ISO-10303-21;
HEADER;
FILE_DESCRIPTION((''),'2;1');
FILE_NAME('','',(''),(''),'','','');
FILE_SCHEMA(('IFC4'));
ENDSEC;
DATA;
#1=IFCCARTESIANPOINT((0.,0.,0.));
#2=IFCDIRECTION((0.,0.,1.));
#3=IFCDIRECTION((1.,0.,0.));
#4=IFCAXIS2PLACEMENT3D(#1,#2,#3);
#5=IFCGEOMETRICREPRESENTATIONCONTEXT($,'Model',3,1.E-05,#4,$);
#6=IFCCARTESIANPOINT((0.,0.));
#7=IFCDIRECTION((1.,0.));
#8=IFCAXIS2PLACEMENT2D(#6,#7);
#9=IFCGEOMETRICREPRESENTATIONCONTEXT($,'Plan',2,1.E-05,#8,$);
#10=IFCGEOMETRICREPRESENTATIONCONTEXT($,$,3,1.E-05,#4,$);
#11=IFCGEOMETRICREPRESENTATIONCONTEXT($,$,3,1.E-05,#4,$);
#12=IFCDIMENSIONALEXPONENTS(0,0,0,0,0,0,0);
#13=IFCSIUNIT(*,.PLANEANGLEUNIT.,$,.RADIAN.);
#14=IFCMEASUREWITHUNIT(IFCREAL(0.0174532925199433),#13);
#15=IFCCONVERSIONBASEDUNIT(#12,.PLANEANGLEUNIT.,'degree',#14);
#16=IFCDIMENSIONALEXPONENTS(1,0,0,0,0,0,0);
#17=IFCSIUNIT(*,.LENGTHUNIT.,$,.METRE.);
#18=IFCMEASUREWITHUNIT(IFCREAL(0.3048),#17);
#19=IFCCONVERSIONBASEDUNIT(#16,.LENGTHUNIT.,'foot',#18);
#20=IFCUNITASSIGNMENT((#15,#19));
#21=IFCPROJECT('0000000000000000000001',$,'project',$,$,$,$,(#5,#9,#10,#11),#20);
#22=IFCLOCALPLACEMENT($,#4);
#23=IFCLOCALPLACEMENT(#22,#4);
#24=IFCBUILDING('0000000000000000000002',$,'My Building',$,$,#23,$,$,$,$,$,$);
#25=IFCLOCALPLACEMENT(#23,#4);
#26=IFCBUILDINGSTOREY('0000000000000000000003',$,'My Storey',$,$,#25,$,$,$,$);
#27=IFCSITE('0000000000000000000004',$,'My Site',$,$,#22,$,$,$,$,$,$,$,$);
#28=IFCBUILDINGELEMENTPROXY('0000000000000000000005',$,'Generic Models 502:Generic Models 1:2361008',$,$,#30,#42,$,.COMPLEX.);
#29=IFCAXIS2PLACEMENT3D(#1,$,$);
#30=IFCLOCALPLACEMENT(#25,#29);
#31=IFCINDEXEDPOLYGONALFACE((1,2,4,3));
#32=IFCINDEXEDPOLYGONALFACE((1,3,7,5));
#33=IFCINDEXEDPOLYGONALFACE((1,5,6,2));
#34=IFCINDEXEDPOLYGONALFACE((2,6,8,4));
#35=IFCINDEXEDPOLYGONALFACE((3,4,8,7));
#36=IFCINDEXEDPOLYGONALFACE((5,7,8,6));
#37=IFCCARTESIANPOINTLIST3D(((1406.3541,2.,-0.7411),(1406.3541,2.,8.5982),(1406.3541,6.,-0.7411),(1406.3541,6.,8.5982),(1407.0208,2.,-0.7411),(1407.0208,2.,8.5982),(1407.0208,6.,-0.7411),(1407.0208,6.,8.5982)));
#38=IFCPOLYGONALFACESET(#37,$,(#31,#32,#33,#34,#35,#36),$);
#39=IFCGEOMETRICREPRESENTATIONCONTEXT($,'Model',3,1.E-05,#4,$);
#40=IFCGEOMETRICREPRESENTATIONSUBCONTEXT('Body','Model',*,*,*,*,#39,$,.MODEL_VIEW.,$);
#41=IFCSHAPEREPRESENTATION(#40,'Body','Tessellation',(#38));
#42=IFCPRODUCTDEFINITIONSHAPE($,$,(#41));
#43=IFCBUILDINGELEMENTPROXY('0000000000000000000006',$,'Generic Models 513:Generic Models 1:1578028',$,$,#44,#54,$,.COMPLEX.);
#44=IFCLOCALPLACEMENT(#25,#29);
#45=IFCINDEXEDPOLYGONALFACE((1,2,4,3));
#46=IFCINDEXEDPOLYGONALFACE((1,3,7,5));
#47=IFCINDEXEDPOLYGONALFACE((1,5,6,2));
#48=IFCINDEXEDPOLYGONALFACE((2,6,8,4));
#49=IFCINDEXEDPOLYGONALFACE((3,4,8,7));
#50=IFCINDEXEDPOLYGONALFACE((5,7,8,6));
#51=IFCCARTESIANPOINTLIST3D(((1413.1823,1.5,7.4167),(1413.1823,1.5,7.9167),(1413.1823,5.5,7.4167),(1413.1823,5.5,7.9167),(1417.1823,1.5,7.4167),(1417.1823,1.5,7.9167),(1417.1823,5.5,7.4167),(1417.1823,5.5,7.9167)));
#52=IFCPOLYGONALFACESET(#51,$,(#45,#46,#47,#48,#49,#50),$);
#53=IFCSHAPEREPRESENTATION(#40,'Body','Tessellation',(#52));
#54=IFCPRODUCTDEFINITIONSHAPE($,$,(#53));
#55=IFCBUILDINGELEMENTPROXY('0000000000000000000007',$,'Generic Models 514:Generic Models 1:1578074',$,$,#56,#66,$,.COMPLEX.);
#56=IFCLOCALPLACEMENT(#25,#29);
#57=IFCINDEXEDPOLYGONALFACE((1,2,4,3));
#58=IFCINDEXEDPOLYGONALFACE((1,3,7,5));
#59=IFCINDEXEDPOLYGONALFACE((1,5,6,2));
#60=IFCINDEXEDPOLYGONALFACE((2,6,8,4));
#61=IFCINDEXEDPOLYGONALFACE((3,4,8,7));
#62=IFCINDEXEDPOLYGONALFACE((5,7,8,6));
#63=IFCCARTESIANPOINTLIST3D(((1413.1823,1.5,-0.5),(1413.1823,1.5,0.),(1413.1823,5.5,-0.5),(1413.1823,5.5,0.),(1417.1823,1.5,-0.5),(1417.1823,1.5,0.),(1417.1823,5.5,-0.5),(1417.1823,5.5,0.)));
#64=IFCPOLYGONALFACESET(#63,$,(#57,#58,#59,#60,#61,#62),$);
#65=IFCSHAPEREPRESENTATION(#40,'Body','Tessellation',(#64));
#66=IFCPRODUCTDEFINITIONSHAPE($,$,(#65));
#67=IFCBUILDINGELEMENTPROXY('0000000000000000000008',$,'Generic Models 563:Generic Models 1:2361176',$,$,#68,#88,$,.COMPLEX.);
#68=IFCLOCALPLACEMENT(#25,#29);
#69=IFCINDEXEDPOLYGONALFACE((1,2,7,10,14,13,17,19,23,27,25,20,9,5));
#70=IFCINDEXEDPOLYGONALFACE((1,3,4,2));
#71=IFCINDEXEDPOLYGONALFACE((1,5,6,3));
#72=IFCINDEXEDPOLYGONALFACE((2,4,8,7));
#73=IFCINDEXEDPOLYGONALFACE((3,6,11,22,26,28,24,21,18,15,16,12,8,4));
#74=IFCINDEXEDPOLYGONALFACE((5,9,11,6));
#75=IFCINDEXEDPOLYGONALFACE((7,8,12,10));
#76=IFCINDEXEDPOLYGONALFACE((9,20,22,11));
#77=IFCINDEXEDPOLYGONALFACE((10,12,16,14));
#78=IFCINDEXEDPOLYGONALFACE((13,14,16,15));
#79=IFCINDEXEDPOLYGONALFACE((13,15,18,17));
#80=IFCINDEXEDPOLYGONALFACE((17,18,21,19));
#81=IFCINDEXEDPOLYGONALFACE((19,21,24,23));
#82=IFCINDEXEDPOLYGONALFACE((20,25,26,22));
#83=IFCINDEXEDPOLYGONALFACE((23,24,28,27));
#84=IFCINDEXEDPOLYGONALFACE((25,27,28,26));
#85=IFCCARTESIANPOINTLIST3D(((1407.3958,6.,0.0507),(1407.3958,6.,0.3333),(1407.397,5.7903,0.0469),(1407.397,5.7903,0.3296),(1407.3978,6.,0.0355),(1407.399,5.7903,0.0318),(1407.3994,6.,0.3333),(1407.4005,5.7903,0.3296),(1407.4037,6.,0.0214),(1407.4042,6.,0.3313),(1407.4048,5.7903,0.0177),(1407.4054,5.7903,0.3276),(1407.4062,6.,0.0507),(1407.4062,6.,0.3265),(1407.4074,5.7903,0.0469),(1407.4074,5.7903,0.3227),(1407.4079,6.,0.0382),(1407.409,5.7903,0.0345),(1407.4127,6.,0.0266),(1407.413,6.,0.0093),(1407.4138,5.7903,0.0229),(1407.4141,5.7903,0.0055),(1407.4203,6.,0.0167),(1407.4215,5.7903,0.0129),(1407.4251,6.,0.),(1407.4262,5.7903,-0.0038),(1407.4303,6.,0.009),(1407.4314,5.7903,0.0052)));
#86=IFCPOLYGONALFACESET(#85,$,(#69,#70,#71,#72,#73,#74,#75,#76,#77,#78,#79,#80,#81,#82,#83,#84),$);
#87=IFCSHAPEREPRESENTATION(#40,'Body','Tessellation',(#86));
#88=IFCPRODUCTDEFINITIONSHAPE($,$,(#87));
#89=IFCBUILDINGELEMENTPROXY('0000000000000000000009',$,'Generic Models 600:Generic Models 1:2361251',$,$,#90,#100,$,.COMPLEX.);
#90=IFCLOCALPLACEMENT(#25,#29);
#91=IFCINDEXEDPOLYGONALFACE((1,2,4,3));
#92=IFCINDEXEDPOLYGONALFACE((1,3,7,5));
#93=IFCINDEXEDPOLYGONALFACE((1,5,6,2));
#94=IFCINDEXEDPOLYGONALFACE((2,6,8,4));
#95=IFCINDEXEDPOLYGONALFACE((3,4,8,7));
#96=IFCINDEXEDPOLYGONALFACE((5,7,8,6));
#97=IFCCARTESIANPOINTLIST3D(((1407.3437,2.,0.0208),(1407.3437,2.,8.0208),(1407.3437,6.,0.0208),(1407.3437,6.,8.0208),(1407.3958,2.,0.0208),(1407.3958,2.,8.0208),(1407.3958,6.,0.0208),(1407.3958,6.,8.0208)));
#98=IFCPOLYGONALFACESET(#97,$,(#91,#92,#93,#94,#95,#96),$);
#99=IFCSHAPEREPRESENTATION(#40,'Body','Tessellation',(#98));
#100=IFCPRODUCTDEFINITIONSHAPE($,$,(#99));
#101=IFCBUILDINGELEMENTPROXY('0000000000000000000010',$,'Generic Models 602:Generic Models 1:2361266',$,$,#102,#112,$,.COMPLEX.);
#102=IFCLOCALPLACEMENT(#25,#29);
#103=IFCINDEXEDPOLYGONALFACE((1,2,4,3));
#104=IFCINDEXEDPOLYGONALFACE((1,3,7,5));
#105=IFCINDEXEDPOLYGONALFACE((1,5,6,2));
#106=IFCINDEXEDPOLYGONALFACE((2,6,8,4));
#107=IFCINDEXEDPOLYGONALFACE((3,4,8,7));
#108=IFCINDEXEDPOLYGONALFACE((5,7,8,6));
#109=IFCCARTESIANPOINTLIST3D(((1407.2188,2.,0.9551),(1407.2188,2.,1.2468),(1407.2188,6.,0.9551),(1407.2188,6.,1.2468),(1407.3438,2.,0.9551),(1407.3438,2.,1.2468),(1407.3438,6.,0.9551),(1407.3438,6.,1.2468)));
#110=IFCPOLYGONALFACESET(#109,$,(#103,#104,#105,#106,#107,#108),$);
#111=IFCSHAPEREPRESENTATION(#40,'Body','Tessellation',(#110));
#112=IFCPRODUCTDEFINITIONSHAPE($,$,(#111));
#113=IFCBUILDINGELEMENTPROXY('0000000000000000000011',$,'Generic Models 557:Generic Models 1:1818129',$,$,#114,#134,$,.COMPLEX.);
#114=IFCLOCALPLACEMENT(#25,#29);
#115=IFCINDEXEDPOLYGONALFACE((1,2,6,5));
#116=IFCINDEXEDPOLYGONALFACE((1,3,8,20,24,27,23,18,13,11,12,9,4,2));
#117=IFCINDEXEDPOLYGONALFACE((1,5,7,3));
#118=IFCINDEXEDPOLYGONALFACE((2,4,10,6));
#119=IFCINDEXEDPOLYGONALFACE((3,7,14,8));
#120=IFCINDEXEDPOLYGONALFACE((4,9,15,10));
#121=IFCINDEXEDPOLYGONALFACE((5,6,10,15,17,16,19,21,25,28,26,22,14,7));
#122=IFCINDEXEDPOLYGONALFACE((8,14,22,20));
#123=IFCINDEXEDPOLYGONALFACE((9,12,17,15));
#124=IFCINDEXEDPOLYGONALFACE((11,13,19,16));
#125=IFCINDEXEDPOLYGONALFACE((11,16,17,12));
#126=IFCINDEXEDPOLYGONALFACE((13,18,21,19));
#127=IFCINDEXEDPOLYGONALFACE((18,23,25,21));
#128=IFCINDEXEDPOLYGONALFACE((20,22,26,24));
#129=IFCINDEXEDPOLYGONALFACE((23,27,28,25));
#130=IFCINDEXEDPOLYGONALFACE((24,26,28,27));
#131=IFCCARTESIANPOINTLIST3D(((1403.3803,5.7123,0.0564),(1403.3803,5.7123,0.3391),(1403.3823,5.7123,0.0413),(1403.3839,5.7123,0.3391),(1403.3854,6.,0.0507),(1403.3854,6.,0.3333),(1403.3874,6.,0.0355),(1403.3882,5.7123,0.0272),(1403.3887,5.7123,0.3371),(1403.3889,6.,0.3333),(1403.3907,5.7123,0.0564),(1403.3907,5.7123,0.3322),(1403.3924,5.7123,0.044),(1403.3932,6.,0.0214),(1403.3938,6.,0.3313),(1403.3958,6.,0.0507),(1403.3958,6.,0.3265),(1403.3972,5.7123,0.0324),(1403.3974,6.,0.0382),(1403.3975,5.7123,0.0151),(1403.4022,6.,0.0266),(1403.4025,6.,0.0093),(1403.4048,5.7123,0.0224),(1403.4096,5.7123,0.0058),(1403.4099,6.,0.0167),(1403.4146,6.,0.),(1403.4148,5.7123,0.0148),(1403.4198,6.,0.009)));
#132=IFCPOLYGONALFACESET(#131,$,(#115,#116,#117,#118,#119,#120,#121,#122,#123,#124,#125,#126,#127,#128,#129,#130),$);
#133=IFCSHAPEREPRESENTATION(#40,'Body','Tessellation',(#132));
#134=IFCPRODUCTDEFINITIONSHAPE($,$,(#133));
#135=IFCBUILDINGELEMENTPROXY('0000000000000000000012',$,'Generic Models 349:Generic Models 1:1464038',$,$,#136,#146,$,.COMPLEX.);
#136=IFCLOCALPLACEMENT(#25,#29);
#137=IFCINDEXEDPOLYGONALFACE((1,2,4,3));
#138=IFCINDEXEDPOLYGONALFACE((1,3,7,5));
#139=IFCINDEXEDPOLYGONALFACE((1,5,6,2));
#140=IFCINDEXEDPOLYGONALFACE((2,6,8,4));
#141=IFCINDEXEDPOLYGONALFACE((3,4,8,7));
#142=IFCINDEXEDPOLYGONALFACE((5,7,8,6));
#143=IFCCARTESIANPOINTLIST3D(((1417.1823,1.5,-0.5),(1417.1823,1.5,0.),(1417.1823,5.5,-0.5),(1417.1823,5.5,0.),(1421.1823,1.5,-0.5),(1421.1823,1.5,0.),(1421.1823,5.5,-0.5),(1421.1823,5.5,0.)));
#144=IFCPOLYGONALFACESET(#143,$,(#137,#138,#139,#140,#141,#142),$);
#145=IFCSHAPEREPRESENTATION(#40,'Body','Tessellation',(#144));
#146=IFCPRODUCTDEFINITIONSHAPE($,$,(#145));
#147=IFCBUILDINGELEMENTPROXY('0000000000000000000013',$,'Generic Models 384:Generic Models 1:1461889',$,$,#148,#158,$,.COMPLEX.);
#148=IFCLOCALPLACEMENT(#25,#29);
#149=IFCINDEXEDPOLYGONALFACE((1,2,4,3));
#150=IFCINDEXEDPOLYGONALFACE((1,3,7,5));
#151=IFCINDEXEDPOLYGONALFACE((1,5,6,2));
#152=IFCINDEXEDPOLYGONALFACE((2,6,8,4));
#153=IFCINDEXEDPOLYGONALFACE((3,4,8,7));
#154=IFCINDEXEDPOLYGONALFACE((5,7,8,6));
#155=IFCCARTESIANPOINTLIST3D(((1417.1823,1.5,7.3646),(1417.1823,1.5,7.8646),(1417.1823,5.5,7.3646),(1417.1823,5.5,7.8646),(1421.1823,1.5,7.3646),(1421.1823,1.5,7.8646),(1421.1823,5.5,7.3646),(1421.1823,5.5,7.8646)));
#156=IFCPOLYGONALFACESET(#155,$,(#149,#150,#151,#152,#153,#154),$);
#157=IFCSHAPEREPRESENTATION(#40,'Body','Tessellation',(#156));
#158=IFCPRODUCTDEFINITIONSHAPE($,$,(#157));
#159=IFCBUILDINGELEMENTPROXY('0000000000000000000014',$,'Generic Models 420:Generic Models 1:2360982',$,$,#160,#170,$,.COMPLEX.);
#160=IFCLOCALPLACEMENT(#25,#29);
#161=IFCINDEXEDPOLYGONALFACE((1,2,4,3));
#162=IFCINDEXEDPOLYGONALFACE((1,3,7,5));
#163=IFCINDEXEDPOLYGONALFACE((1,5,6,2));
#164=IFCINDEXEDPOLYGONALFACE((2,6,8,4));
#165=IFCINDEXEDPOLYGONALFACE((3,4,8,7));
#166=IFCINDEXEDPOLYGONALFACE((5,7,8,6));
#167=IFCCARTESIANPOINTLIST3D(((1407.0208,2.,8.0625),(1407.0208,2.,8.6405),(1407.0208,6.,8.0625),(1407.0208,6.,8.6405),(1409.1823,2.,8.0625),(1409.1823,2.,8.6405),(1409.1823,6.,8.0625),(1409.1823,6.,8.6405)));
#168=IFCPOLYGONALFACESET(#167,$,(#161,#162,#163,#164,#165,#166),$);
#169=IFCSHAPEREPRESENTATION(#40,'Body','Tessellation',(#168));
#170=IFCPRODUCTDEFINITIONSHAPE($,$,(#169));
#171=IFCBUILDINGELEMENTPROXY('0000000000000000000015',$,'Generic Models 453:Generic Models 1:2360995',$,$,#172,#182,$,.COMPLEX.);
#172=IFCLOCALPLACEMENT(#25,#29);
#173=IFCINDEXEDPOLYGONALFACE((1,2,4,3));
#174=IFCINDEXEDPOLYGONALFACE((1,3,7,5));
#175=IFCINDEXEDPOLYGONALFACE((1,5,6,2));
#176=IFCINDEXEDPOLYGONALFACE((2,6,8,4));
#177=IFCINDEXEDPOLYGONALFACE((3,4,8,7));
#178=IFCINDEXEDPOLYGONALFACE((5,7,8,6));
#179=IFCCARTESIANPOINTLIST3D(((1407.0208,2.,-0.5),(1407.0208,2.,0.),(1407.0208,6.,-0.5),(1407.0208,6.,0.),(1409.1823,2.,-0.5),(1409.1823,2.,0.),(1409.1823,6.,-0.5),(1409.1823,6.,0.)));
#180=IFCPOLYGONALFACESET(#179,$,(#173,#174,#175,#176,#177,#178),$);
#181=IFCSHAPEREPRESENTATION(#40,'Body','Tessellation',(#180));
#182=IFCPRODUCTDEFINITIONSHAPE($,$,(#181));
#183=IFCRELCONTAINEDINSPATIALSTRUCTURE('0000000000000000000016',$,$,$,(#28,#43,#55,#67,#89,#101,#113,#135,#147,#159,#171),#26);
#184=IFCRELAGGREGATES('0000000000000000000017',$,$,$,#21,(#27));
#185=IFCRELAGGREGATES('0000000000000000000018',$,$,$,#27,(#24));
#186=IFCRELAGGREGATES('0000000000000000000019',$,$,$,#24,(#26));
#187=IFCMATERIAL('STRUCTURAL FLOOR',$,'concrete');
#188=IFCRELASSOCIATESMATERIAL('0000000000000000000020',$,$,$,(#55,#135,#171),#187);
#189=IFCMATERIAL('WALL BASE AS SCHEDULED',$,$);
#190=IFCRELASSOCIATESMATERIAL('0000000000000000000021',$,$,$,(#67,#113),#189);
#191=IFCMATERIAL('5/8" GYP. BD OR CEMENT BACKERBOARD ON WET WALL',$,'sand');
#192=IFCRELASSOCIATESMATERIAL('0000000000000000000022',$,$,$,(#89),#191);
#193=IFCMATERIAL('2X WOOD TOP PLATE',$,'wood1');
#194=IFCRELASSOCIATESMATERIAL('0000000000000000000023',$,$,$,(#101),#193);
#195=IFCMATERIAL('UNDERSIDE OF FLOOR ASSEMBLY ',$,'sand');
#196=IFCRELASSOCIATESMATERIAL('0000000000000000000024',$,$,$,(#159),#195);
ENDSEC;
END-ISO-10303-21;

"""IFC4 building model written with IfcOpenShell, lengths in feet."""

from ifc_helpers import new_model, entity, si_unit, converted_unit, frame, origin_with_axes, origin_2d_with_axis, place, context, subcontext, project, spatial, polyline, outline, extrude, material, element, save


model = new_model("IFC4")

# Units and contexts
model_context_1 = context("Model", 3, precision=1e-05, world=origin_with_axes())
plan_context = context("Plan", 2, precision=1e-05, world=origin_2d_with_axis())
model_context_2 = context("Model", 3, precision=1e-05, world=origin_with_axes())
context_of_model_1 = context(None, 3, precision=1e-05, world=origin_with_axes())
context_of_model_2 = context(None, 3, precision=1e-05, world=origin_with_axes())
body_context = subcontext(model_context_2, "Body", "Model", "MODEL_VIEW")
ifc_project = project(units=[converted_unit("PLANEANGLEUNIT", "degree", entity("IfcReal", 0.0174532925199433), si_unit("PLANEANGLEUNIT", "RADIAN"), dimensions=[0, 0, 0, 0, 0, 0, 0]), converted_unit("LENGTHUNIT", "foot", entity("IfcReal", 0.3048), si_unit("LENGTHUNIT", "METRE"), dimensions=[1, 0, 0, 0, 0, 0, 0])], contexts=[model_context_1, plan_context, context_of_model_1, context_of_model_2])

# Site, building, storey
site_placement = place(None, origin_with_axes())
site = spatial("IfcSite", under=ifc_project, at=site_placement, Name="My Site")
building_placement = place(site_placement, origin_with_axes())
building = spatial("IfcBuilding", under=site, at=building_placement, Name="My Building")
storey_placement = place(building_placement, origin_with_axes())
storey = spatial("IfcBuildingStorey", under=building, at=storey_placement, Name="My Storey")

# Building element proxies
proxy_1_placement = place(storey_placement, frame((1406.3541, 6.0, -0.7411), z_axis=(0.0, -1.0, 0.0), x_axis=(0.0, 0.0, 1.0)))
element("IfcBuildingElementProxy", 1, at=proxy_1_placement, inside=storey, Name="Generic Models 502:Generic Models 1:2361008", PredefinedType="COMPLEX", context=body_context, shape_type="SweptSolid", body=[
    extrude(outline(polyline([(-0.3333, -4.6697), (0.3333, -4.6697), (0.3333, 4.6697), (-0.3333, 4.6697), (-0.3333, -4.6697)])), frame((4.6697, -0.3333, 0.0), z_axis=(0.0, 0.0, -1.0), x_axis=(0.0, 1.0, 0.0)), (0.0, 0.0, -1.0), 4.0),
])
proxy_2_placement = place(storey_placement, frame((1413.1823, 5.5, 7.4167), z_axis=(0.0, -1.0, 0.0), x_axis=(0.0, 0.0, 1.0)))
element("IfcBuildingElementProxy", 2, at=proxy_2_placement, inside=storey, Name="Generic Models 513:Generic Models 1:1578028", PredefinedType="COMPLEX", context=body_context, shape_type="SweptSolid", body=[
    extrude(outline(polyline([(-0.25, -2.0), (0.25, -2.0), (0.25, 2.0), (-0.25, 2.0), (-0.25, -2.0)])), frame((0.25, -2.0, 0.0), z_axis=(0.0, 0.0, -1.0), x_axis=(1.0, 0.0, 0.0)), (0.0, 0.0, -1.0), 4.0),
])
ifc_material_1 = material(Name="STRUCTURAL FLOOR", Category="concrete")
proxy_3_placement = place(storey_placement, frame((1413.1823, 5.5, -0.5), z_axis=(0.0, -1.0, 0.0), x_axis=(0.0, 0.0, 1.0)))
element("IfcBuildingElementProxy", 3, at=proxy_3_placement, inside=storey, material=ifc_material_1, Name="Generic Models 514:Generic Models 1:1578074", PredefinedType="COMPLEX", context=body_context, shape_type="SweptSolid", body=[
    extrude(outline(polyline([(-0.25, -2.0), (0.25, -2.0), (0.25, 2.0), (-0.25, 2.0), (-0.25, -2.0)])), frame((0.25, -2.0, 0.0), z_axis=(0.0, 0.0, -1.0), x_axis=(1.0, 0.0, 0.0)), (0.0, 0.0, -1.0), 4.0),
])
ifc_material_2 = material(Name="WALL BASE AS SCHEDULED")
proxy_4_placement = place(storey_placement, frame((1407.3958, 6.0, 0.0), z_axis=(0.0, -1.0, 0.0), x_axis=(0.0, 0.0, 1.0)))
element("IfcBuildingElementProxy", 4, at=proxy_4_placement, inside=storey, material=ifc_material_2, Name="Generic Models 563:Generic Models 1:2361176", PredefinedType="COMPLEX", context=body_context, shape_type="SweptSolid", body=[
    extrude(outline(polyline([(0.0971, 0.0), (0.1059, -0.009), (0.1142, -0.0027), (0.1035, 0.0082), (0.0904, 0.016), (0.0756, 0.02), (0.0603, 0.0202), (-0.2202, -0.0144), (-0.2197, -0.0179), (-0.2172, -0.0225), (-0.2121, -0.0239), (0.0616, 0.0098), (0.0742, 0.0097), (0.0863, 0.0064), (0.0971, 0.0)])), frame((0.113, -0.0126, 0.0), z_axis=(0.0, 0.0, -1.0), x_axis=(-0.992503, -0.12222, 0.0)), (0.01852, -0.003236, -0.999823), 0.2098),
])
ifc_material_3 = material(Name="5/8\" GYP. BD OR CEMENT BACKERBOARD ON WET WALL", Category="sand")
proxy_5_placement = place(storey_placement, frame((1407.3437, 6.0, 0.0208), z_axis=(0.0, -1.0, 0.0), x_axis=(0.0, 0.0, 1.0)))
element("IfcBuildingElementProxy", 5, at=proxy_5_placement, inside=storey, material=ifc_material_3, Name="Generic Models 600:Generic Models 1:2361251", PredefinedType="COMPLEX", context=body_context, shape_type="SweptSolid", body=[
    extrude(outline(polyline([(-4.0, -0.026), (4.0, -0.026), (4.0, 0.026), (-4.0, 0.026), (-4.0, -0.026)])), frame((4.0, -0.026, 0.0), z_axis=(0.0, 0.0, -1.0), x_axis=(1.0, 0.0, 0.0)), (0.0, 0.0, -1.0), 4.0),
])
ifc_material_4 = material(Name="2X WOOD TOP PLATE", Category="wood1")
proxy_6_placement = place(storey_placement, frame((1407.2188, 6.0, 0.9551), z_axis=(0.0, -1.0, 0.0), x_axis=(0.0, 0.0, 1.0)))
element("IfcBuildingElementProxy", 6, at=proxy_6_placement, inside=storey, material=ifc_material_4, Name="Generic Models 602:Generic Models 1:2361266", PredefinedType="COMPLEX", context=body_context, shape_type="SweptSolid", body=[
    extrude(outline(polyline([(-0.1458, -0.0625), (0.1458, -0.0625), (0.1458, 0.0625), (-0.1458, 0.0625), (-0.1458, -0.0625)])), frame((0.1458, -0.0625, 0.0), z_axis=(0.0, 0.0, -1.0), x_axis=(1.0, 0.0, 0.0)), (0.0, 0.0, -1.0), 4.0),
])
proxy_7_placement = place(storey_placement, frame((1403.3854, 6.0, 0.0), z_axis=(0.0, -1.0, 0.0), x_axis=(0.0, 0.0, 1.0)))
element("IfcBuildingElementProxy", 7, at=proxy_7_placement, inside=storey, material=ifc_material_2, Name="Generic Models 557:Generic Models 1:1818129", PredefinedType="COMPLEX", context=body_context, shape_type="SweptSolid", body=[
    extrude(outline(polyline([(0.1038, 0.0), (0.0913, 0.0088), (0.077, 0.014), (0.0618, 0.0153), (-0.2206, 0.0031), (-0.2205, -0.0005), (-0.2183, -0.0052), (-0.2133, -0.007), (0.0622, 0.0049), (0.0747, 0.0038), (0.0865, -0.0005), (0.0968, -0.0077), (0.1049, -0.0173), (0.1137, -0.0117), (0.1038, 0.0)])), frame((0.113, -0.0126, 0.0), z_axis=(0.0, 0.0, -1.0), x_axis=(-0.999059, -0.043362, 0.0)), (-0.020742, 0.016656, -0.999646), 0.2878),
])
proxy_8_placement = place(storey_placement, frame((1417.1823, 5.5, -0.5), z_axis=(0.0, -1.0, 0.0), x_axis=(0.0, 0.0, 1.0)))
element("IfcBuildingElementProxy", 8, at=proxy_8_placement, inside=storey, material=ifc_material_1, Name="Generic Models 349:Generic Models 1:1464038", PredefinedType="COMPLEX", context=body_context, shape_type="SweptSolid", body=[
    extrude(outline(polyline([(-0.25, -2.0), (0.25, -2.0), (0.25, 2.0), (-0.25, 2.0), (-0.25, -2.0)])), frame((0.25, -2.0, 0.0), z_axis=(0.0, 0.0, -1.0), x_axis=(1.0, 0.0, 0.0)), (0.0, 0.0, -1.0), 4.0),
])
proxy_9_placement = place(storey_placement, frame((1417.1823, 5.5, 7.3646), z_axis=(0.0, -1.0, 0.0), x_axis=(0.0, 0.0, 1.0)))
element("IfcBuildingElementProxy", 9, at=proxy_9_placement, inside=storey, Name="Generic Models 384:Generic Models 1:1461889", PredefinedType="COMPLEX", context=body_context, shape_type="SweptSolid", body=[
    extrude(outline(polyline([(-0.25, -2.0), (0.25, -2.0), (0.25, 2.0), (-0.25, 2.0), (-0.25, -2.0)])), frame((0.25, -2.0, 0.0), z_axis=(0.0, 0.0, -1.0), x_axis=(1.0, 0.0, 0.0)), (0.0, 0.0, -1.0), 4.0),
])
ifc_material_5 = material(Name="UNDERSIDE OF FLOOR ASSEMBLY ", Category="sand")
proxy_10_placement = place(storey_placement, frame((1407.0208, 6.0, 8.0625), z_axis=(0.0, -1.0, 0.0), x_axis=(0.0, 0.0, 1.0)))
element("IfcBuildingElementProxy", 10, at=proxy_10_placement, inside=storey, material=ifc_material_5, Name="Generic Models 420:Generic Models 1:2360982", PredefinedType="COMPLEX", context=body_context, shape_type="SweptSolid", body=[
    extrude(outline(polyline([(-0.289, -1.0807), (0.289, -1.0807), (0.289, 1.0807), (-0.289, 1.0807), (-0.289, -1.0807)])), frame((0.289, -1.0807, 0.0), z_axis=(0.0, 0.0, -1.0), x_axis=(1.0, 0.0, 0.0)), (0.0, 0.0, -1.0), 4.0),
])
proxy_11_placement = place(storey_placement, frame((1407.0208, 6.0, -0.5), z_axis=(0.0, -1.0, 0.0), x_axis=(0.0, 0.0, 1.0)))
element("IfcBuildingElementProxy", 11, at=proxy_11_placement, inside=storey, material=ifc_material_1, Name="Generic Models 453:Generic Models 1:2360995", PredefinedType="COMPLEX", context=body_context, shape_type="SweptSolid", body=[
    extrude(outline(polyline([(-0.25, -1.0807), (0.25, -1.0807), (0.25, 1.0807), (-0.25, 1.0807), (-0.25, -1.0807)])), frame((0.25, -1.0807, 0.0), z_axis=(0.0, 0.0, -1.0), x_axis=(1.0, 0.0, 0.0)), (0.0, 0.0, -1.0), 4.0),
])

save(model, "model.ifc")
